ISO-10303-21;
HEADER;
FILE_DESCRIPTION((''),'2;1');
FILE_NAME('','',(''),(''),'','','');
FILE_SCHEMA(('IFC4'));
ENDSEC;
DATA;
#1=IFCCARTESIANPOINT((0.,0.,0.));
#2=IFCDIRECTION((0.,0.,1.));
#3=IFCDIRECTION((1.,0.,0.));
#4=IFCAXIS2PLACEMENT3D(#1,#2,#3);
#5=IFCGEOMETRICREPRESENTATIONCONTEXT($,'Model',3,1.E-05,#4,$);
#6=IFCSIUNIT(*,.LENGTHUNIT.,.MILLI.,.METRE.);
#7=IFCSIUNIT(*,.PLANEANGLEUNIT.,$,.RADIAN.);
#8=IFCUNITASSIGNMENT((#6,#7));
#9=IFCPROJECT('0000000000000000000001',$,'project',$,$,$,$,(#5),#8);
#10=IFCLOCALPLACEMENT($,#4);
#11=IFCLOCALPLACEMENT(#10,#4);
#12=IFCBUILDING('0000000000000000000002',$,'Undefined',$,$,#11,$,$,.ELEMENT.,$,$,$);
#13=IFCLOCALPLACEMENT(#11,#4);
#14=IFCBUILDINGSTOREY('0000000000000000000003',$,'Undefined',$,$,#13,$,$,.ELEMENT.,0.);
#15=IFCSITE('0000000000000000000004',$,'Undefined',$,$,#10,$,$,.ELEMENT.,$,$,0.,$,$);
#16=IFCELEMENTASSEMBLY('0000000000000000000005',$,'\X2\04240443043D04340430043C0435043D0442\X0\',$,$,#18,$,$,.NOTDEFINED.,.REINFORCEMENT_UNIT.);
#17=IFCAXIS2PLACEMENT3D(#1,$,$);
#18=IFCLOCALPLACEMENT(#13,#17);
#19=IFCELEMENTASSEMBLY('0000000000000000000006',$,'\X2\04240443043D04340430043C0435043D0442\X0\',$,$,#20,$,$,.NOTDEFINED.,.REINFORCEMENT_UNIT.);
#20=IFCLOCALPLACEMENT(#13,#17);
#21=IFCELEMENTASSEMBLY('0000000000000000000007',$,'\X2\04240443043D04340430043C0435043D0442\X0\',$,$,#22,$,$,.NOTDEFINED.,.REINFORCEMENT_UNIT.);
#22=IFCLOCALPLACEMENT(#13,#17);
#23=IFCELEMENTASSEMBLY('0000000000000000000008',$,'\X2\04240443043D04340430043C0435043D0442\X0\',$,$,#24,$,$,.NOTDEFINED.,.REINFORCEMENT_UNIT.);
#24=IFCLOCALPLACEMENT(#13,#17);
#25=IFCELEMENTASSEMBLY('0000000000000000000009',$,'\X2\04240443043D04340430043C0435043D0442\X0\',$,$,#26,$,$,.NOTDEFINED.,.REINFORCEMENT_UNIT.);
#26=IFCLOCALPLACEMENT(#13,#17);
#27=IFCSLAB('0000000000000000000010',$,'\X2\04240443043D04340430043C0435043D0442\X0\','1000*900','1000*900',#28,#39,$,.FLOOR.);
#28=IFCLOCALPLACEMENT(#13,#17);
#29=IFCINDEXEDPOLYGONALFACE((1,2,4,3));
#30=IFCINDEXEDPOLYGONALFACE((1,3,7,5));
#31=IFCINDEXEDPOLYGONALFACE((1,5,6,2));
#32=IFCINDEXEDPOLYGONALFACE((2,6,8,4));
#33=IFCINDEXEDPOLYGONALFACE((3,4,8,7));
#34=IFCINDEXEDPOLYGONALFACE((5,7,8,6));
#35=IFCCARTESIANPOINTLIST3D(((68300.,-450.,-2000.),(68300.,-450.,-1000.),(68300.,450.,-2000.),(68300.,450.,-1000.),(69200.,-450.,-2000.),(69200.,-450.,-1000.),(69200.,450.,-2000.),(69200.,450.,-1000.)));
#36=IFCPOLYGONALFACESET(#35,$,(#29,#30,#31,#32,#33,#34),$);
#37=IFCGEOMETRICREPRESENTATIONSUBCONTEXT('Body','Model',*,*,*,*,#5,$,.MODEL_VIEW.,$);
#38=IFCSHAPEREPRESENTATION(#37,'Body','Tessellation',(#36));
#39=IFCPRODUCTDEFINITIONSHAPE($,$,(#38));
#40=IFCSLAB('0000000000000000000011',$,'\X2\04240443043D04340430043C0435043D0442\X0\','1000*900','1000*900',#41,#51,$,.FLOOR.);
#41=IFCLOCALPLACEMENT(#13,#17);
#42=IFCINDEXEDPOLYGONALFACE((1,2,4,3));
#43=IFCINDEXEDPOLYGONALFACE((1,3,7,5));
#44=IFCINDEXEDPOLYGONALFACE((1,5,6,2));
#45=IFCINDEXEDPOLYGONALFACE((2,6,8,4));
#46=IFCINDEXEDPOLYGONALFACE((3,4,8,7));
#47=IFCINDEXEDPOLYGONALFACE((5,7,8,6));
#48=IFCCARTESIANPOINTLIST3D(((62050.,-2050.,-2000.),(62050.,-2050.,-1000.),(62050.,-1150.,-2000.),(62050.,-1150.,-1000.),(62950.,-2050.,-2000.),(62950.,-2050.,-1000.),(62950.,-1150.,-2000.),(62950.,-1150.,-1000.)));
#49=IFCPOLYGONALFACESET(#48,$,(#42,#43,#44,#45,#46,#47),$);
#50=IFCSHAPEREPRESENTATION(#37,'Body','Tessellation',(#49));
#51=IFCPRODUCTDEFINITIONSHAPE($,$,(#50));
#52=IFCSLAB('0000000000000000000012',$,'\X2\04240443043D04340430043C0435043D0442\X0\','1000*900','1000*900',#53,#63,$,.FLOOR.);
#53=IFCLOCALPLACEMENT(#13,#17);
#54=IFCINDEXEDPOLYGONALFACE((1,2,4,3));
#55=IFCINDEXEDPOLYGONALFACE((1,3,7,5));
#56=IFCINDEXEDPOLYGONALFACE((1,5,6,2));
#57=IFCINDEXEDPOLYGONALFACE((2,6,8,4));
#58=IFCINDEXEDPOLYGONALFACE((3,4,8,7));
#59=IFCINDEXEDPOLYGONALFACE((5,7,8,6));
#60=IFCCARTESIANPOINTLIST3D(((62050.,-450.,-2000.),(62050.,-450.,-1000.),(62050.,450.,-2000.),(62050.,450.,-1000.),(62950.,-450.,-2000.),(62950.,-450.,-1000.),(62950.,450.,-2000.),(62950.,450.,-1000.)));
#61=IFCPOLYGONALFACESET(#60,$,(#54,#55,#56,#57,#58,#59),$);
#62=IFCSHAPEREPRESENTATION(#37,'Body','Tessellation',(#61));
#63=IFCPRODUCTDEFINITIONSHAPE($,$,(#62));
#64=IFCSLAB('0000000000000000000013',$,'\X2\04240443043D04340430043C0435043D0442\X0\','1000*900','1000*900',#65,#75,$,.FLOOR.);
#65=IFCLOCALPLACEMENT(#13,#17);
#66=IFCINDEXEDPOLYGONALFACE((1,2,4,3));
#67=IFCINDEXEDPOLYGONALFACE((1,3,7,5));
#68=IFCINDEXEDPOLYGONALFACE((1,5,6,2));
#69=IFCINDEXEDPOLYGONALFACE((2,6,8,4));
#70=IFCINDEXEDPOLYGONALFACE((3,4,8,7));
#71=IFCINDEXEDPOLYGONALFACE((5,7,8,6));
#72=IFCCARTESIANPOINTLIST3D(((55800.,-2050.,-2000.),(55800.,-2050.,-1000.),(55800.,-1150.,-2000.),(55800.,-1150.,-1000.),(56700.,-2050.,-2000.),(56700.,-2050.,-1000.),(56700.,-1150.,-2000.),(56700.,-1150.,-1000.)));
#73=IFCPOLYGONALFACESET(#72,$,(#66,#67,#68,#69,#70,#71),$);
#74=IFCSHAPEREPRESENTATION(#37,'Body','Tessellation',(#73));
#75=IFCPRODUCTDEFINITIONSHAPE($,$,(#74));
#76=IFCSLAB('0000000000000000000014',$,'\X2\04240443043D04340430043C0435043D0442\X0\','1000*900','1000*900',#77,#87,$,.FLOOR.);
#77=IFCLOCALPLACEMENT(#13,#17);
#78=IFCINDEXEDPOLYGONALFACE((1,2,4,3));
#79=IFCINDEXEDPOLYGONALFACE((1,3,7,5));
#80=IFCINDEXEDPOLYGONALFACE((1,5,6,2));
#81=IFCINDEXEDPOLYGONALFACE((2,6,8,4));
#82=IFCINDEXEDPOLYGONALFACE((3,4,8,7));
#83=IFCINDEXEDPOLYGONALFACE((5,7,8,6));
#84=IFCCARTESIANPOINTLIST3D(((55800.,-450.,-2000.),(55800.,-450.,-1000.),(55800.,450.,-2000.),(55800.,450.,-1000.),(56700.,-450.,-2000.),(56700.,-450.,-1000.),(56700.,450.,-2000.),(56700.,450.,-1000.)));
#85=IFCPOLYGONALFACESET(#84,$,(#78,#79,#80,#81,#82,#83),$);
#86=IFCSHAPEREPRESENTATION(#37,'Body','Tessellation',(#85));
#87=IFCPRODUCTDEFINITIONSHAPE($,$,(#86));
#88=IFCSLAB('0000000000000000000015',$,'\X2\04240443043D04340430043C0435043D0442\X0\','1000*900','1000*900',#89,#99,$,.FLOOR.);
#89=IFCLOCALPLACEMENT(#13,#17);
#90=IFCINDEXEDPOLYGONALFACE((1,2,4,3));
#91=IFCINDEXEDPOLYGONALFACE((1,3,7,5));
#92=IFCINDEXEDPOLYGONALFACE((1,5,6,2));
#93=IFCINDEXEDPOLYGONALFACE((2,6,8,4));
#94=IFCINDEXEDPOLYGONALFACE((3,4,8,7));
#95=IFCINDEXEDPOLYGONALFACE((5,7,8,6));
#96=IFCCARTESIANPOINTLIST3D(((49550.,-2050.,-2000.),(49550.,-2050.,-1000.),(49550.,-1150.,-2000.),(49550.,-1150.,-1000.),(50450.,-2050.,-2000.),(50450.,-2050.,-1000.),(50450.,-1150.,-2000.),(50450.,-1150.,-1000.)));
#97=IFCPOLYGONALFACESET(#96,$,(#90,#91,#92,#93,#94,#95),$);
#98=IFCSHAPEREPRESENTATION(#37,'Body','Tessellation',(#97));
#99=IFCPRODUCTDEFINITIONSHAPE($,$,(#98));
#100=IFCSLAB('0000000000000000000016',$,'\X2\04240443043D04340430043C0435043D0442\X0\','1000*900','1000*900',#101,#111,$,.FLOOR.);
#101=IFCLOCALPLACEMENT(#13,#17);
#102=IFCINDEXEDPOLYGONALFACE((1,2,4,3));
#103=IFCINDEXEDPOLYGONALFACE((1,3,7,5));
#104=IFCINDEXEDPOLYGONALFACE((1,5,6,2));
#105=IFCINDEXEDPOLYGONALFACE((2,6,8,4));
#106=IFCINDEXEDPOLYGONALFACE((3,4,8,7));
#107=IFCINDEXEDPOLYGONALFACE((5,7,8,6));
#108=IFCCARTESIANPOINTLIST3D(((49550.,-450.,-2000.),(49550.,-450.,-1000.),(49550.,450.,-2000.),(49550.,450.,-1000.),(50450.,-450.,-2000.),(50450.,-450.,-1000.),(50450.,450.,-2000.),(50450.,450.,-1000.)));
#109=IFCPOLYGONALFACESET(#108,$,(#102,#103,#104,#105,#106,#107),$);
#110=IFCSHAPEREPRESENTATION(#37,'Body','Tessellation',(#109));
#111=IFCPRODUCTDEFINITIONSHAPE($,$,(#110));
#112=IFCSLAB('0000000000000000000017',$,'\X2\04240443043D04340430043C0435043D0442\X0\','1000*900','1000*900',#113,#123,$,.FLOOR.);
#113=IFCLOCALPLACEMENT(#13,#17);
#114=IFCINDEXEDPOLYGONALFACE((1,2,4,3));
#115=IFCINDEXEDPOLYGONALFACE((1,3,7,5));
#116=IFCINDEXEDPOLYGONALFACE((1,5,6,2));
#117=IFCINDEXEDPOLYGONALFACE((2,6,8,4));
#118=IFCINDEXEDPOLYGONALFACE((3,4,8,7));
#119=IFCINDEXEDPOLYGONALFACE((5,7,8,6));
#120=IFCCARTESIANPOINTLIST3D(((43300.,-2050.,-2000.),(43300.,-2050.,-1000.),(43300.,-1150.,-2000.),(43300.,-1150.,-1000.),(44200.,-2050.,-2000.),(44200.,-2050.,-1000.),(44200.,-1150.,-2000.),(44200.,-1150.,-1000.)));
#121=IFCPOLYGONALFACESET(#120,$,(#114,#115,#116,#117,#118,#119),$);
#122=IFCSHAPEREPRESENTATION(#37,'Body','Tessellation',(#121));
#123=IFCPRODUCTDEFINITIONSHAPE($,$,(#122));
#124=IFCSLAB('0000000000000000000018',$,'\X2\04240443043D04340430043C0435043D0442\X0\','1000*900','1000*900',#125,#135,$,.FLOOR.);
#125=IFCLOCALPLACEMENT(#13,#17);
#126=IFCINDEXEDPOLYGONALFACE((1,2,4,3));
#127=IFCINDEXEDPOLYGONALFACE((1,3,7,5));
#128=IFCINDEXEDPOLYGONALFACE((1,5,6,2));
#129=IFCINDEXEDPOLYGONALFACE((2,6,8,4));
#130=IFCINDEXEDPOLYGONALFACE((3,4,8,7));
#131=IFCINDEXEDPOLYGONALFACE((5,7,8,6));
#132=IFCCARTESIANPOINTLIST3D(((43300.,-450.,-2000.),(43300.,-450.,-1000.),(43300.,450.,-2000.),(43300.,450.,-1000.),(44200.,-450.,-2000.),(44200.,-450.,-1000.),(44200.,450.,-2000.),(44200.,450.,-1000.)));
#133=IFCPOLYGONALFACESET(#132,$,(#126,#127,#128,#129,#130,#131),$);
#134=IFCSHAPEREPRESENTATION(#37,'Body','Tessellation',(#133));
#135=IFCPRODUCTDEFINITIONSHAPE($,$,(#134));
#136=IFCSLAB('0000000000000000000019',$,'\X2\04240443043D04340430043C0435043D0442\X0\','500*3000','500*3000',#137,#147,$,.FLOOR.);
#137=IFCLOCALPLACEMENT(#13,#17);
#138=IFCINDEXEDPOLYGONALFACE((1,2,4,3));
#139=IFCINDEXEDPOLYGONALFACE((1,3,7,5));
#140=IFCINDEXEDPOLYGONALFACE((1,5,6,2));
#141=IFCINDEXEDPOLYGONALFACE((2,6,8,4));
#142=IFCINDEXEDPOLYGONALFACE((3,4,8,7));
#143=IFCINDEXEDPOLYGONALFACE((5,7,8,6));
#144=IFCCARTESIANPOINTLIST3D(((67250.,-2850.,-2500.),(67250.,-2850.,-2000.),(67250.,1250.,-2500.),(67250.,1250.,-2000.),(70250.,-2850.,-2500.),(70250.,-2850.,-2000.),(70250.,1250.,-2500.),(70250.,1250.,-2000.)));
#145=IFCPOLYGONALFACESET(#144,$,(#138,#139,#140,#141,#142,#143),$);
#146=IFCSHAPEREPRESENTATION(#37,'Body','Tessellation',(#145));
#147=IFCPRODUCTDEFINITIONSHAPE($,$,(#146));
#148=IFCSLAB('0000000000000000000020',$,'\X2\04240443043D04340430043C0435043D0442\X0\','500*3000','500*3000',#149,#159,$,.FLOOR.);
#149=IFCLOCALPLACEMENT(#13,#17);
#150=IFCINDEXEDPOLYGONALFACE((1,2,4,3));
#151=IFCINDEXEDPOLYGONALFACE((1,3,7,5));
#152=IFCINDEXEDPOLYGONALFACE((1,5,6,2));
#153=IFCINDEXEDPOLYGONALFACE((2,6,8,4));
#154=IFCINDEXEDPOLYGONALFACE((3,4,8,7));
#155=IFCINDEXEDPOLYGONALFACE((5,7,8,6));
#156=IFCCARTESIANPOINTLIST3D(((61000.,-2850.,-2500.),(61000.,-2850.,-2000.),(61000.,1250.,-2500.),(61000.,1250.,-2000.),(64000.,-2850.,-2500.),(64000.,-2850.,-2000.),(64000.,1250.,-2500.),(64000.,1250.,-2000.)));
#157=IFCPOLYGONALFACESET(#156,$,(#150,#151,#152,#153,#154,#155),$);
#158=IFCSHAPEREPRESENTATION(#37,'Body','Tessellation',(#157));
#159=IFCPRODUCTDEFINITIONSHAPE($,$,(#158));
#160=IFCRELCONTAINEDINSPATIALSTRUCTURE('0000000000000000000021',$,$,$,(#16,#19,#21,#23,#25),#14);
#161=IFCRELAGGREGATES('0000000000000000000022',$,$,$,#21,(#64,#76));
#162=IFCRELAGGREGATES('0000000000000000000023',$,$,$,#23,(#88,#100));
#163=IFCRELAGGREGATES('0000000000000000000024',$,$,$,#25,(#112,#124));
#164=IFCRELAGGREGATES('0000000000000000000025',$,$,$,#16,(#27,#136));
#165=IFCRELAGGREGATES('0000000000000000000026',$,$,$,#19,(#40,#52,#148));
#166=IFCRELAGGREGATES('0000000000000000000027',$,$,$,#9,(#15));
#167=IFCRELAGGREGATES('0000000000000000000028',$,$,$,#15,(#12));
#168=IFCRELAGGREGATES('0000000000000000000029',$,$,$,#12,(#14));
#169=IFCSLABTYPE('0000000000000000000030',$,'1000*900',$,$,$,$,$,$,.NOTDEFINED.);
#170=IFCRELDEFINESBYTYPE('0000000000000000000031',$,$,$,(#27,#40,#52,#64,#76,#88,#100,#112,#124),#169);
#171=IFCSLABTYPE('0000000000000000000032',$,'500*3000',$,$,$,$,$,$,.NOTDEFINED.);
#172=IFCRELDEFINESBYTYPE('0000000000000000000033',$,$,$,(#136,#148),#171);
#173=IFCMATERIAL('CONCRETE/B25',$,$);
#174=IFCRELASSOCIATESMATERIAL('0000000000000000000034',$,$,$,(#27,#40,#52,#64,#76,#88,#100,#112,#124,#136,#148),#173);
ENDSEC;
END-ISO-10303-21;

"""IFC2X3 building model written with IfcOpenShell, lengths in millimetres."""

from ifc_helpers import new_model, si_unit, frame, origin_with_axes, place, context, subcontext, project, spatial, polyline, outline, extrude, material, type_object, element, aggregate, save


model = new_model("IFC2X3")

# Units and contexts
model_context = context("Model", 3, precision=1e-05, world=origin_with_axes())
body_context = subcontext(model_context, "Body", "Model", "MODEL_VIEW")
ifc_project = project(units=[si_unit("LENGTHUNIT", "METRE", prefix="MILLI"), si_unit("PLANEANGLEUNIT", "RADIAN")], contexts=[model_context])

# Site, building, storey
site_placement = place(None, origin_with_axes())
site = spatial("IfcSite", under=ifc_project, at=site_placement, Name="Undefined", CompositionType="ELEMENT", RefElevation=0.0)
building_placement = place(site_placement, origin_with_axes())
building = spatial("IfcBuilding", under=site, at=building_placement, Name="Undefined", CompositionType="ELEMENT")
storey_placement = place(building_placement, origin_with_axes())
storey = spatial("IfcBuildingStorey", under=building, at=storey_placement, Name="Undefined", CompositionType="ELEMENT", Elevation=0.0)

# Element assemblies
assembly_1_placement = place(storey_placement, origin_with_axes())
assembly_1 = element("IfcElementAssembly", 1, at=assembly_1_placement, inside=storey, Name="Фундамент", AssemblyPlace="NOTDEFINED", PredefinedType="REINFORCEMENT_UNIT")
ifc_material = material(Name="CONCRETE/B25")
assembly_2_placement = place(storey_placement, origin_with_axes())
assembly_2 = element("IfcElementAssembly", 2, at=assembly_2_placement, inside=storey, Name="Фундамент", AssemblyPlace="NOTDEFINED", PredefinedType="REINFORCEMENT_UNIT")
assembly_3_placement = place(storey_placement, origin_with_axes())
assembly_3 = element("IfcElementAssembly", 3, at=assembly_3_placement, inside=storey, Name="Фундамент", AssemblyPlace="NOTDEFINED", PredefinedType="REINFORCEMENT_UNIT")
assembly_4_placement = place(storey_placement, origin_with_axes())
assembly_4 = element("IfcElementAssembly", 4, at=assembly_4_placement, inside=storey, Name="Фундамент", AssemblyPlace="NOTDEFINED", PredefinedType="REINFORCEMENT_UNIT")
assembly_5_placement = place(storey_placement, origin_with_axes())
assembly_5 = element("IfcElementAssembly", 5, at=assembly_5_placement, inside=storey, Name="Фундамент", AssemblyPlace="NOTDEFINED", PredefinedType="REINFORCEMENT_UNIT")

# Slabs
slab_type_1 = type_object("IfcSlabType", Name="1000*900", PredefinedType="NOTDEFINED")
slab_1_placement = place(assembly_1_placement, frame((68300.0, 450.0, -1500.0), z_axis=(0.0, 0.0, 1.0), x_axis=(0.0, -1.0, 0.0)))
slab_1 = element("IfcSlab", 6, at=slab_1_placement, type_object=slab_type_1, material=ifc_material, Name="Фундамент", Description="1000*900", ObjectType="1000*900", PredefinedType="FLOOR", context=body_context, shape_type="SweptSolid", body=[
    extrude(outline(polyline([(0.0, 0.0), (900.0, 0.0), (900.0, 900.0), (0.0, 900.0), (0.0, 0.0)])), frame((0.0, 0.0, -500.0), z_axis=(0.0, 0.0, 1.0), x_axis=(1.0, 0.0, 0.0)), (0.0, 0.0, 1.0), 1000.0),
])
slab_2_placement = place(assembly_2_placement, frame((62050.0, -1150.0, -1500.0), z_axis=(0.0, 0.0, 1.0), x_axis=(0.0, -1.0, 0.0)))
slab_2 = element("IfcSlab", 7, at=slab_2_placement, type_object=slab_type_1, material=ifc_material, Name="Фундамент", Description="1000*900", ObjectType="1000*900", PredefinedType="FLOOR", context=body_context, shape_type="SweptSolid", body=[
    extrude(outline(polyline([(0.0, 0.0), (900.0, 0.0), (900.0, 900.0), (0.0, 900.0), (0.0, 0.0)])), frame((0.0, 0.0, -500.0), z_axis=(0.0, 0.0, 1.0), x_axis=(1.0, 0.0, 0.0)), (0.0, 0.0, 1.0), 1000.0),
])
slab_3_placement = place(assembly_2_placement, frame((62050.0, 450.0, -1500.0), z_axis=(0.0, 0.0, 1.0), x_axis=(0.0, -1.0, 0.0)))
slab_3 = element("IfcSlab", 8, at=slab_3_placement, type_object=slab_type_1, material=ifc_material, Name="Фундамент", Description="1000*900", ObjectType="1000*900", PredefinedType="FLOOR", context=body_context, shape_type="SweptSolid", body=[
    extrude(outline(polyline([(0.0, 0.0), (900.0, 0.0), (900.0, 900.0), (0.0, 900.0), (0.0, 0.0)])), frame((0.0, 0.0, -500.0), z_axis=(0.0, 0.0, 1.0), x_axis=(1.0, 0.0, 0.0)), (0.0, 0.0, 1.0), 1000.0),
])
slab_4_placement = place(assembly_3_placement, frame((55800.0, -1150.0, -1500.0), z_axis=(0.0, 0.0, 1.0), x_axis=(0.0, -1.0, 0.0)))
slab_4 = element("IfcSlab", 9, at=slab_4_placement, type_object=slab_type_1, material=ifc_material, Name="Фундамент", Description="1000*900", ObjectType="1000*900", PredefinedType="FLOOR", context=body_context, shape_type="SweptSolid", body=[
    extrude(outline(polyline([(0.0, 0.0), (900.0, 0.0), (900.0, 900.0), (0.0, 900.0), (0.0, 0.0)])), frame((0.0, 0.0, -500.0), z_axis=(0.0, 0.0, 1.0), x_axis=(1.0, 0.0, 0.0)), (0.0, 0.0, 1.0), 1000.0),
])
slab_5_placement = place(assembly_3_placement, frame((55800.0, 450.0, -1500.0), z_axis=(0.0, 0.0, 1.0), x_axis=(0.0, -1.0, 0.0)))
slab_5 = element("IfcSlab", 10, at=slab_5_placement, type_object=slab_type_1, material=ifc_material, Name="Фундамент", Description="1000*900", ObjectType="1000*900", PredefinedType="FLOOR", context=body_context, shape_type="SweptSolid", body=[
    extrude(outline(polyline([(0.0, 0.0), (900.0, 0.0), (900.0, 900.0), (0.0, 900.0), (0.0, 0.0)])), frame((0.0, 0.0, -500.0), z_axis=(0.0, 0.0, 1.0), x_axis=(1.0, 0.0, 0.0)), (0.0, 0.0, 1.0), 1000.0),
])
aggregate(assembly_3, [slab_4, slab_5])
slab_6_placement = place(assembly_4_placement, frame((49550.0, -1150.0, -1500.0), z_axis=(0.0, 0.0, 1.0), x_axis=(0.0, -1.0, 0.0)))
slab_6 = element("IfcSlab", 11, at=slab_6_placement, type_object=slab_type_1, material=ifc_material, Name="Фундамент", Description="1000*900", ObjectType="1000*900", PredefinedType="FLOOR", context=body_context, shape_type="SweptSolid", body=[
    extrude(outline(polyline([(0.0, 0.0), (900.0, 0.0), (900.0, 900.0), (0.0, 900.0), (0.0, 0.0)])), frame((0.0, 0.0, -500.0), z_axis=(0.0, 0.0, 1.0), x_axis=(1.0, 0.0, 0.0)), (0.0, 0.0, 1.0), 1000.0),
])
slab_7_placement = place(assembly_4_placement, frame((49550.0, 450.0, -1500.0), z_axis=(0.0, 0.0, 1.0), x_axis=(0.0, -1.0, 0.0)))
slab_7 = element("IfcSlab", 12, at=slab_7_placement, type_object=slab_type_1, material=ifc_material, Name="Фундамент", Description="1000*900", ObjectType="1000*900", PredefinedType="FLOOR", context=body_context, shape_type="SweptSolid", body=[
    extrude(outline(polyline([(0.0, 0.0), (900.0, 0.0), (900.0, 900.0), (0.0, 900.0), (0.0, 0.0)])), frame((0.0, 0.0, -500.0), z_axis=(0.0, 0.0, 1.0), x_axis=(1.0, 0.0, 0.0)), (0.0, 0.0, 1.0), 1000.0),
])
aggregate(assembly_4, [slab_6, slab_7])
slab_8_placement = place(assembly_5_placement, frame((43300.0, -1150.0, -1500.0), z_axis=(0.0, 0.0, 1.0), x_axis=(0.0, -1.0, 0.0)))
slab_8 = element("IfcSlab", 13, at=slab_8_placement, type_object=slab_type_1, material=ifc_material, Name="Фундамент", Description="1000*900", ObjectType="1000*900", PredefinedType="FLOOR", context=body_context, shape_type="SweptSolid", body=[
    extrude(outline(polyline([(0.0, 0.0), (900.0, 0.0), (900.0, 900.0), (0.0, 900.0), (0.0, 0.0)])), frame((0.0, 0.0, -500.0), z_axis=(0.0, 0.0, 1.0), x_axis=(1.0, 0.0, 0.0)), (0.0, 0.0, 1.0), 1000.0),
])
slab_9_placement = place(assembly_5_placement, frame((43300.0, 450.0, -1500.0), z_axis=(0.0, 0.0, 1.0), x_axis=(0.0, -1.0, 0.0)))
slab_9 = element("IfcSlab", 14, at=slab_9_placement, type_object=slab_type_1, material=ifc_material, Name="Фундамент", Description="1000*900", ObjectType="1000*900", PredefinedType="FLOOR", context=body_context, shape_type="SweptSolid", body=[
    extrude(outline(polyline([(0.0, 0.0), (900.0, 0.0), (900.0, 900.0), (0.0, 900.0), (0.0, 0.0)])), frame((0.0, 0.0, -500.0), z_axis=(0.0, 0.0, 1.0), x_axis=(1.0, 0.0, 0.0)), (0.0, 0.0, 1.0), 1000.0),
])
aggregate(assembly_5, [slab_8, slab_9])
slab_type_2 = type_object("IfcSlabType", Name="500*3000", PredefinedType="NOTDEFINED")
slab_10_placement = place(assembly_1_placement, frame((67250.0, 1250.0, -2250.0), z_axis=(0.0, 0.0, 1.0), x_axis=(0.0, -1.0, 0.0)))
slab_10 = element("IfcSlab", 15, at=slab_10_placement, type_object=slab_type_2, material=ifc_material, Name="Фундамент", Description="500*3000", ObjectType="500*3000", PredefinedType="FLOOR", context=body_context, shape_type="SweptSolid", body=[
    extrude(outline(polyline([(0.0, 0.0), (4100.0, 0.0), (4100.0, 3000.0), (0.0, 3000.0), (0.0, 0.0)])), frame((0.0, 0.0, -250.0), z_axis=(0.0, 0.0, 1.0), x_axis=(1.0, 0.0, 0.0)), (0.0, 0.0, 1.0), 500.0),
])
aggregate(assembly_1, [slab_1, slab_10])
slab_11_placement = place(assembly_2_placement, frame((61000.0, 1250.0, -2250.0), z_axis=(0.0, 0.0, 1.0), x_axis=(0.0, -1.0, 0.0)))
slab_11 = element("IfcSlab", 16, at=slab_11_placement, type_object=slab_type_2, material=ifc_material, Name="Фундамент", Description="500*3000", ObjectType="500*3000", PredefinedType="FLOOR", context=body_context, shape_type="SweptSolid", body=[
    extrude(outline(polyline([(0.0, 0.0), (4100.0, 0.0), (4100.0, 3000.0), (0.0, 3000.0), (0.0, 0.0)])), frame((0.0, 0.0, -250.0), z_axis=(0.0, 0.0, 1.0), x_axis=(1.0, 0.0, 0.0)), (0.0, 0.0, 1.0), 500.0),
])
aggregate(assembly_2, [slab_2, slab_3, slab_11])

save(model, "model.ifc")
